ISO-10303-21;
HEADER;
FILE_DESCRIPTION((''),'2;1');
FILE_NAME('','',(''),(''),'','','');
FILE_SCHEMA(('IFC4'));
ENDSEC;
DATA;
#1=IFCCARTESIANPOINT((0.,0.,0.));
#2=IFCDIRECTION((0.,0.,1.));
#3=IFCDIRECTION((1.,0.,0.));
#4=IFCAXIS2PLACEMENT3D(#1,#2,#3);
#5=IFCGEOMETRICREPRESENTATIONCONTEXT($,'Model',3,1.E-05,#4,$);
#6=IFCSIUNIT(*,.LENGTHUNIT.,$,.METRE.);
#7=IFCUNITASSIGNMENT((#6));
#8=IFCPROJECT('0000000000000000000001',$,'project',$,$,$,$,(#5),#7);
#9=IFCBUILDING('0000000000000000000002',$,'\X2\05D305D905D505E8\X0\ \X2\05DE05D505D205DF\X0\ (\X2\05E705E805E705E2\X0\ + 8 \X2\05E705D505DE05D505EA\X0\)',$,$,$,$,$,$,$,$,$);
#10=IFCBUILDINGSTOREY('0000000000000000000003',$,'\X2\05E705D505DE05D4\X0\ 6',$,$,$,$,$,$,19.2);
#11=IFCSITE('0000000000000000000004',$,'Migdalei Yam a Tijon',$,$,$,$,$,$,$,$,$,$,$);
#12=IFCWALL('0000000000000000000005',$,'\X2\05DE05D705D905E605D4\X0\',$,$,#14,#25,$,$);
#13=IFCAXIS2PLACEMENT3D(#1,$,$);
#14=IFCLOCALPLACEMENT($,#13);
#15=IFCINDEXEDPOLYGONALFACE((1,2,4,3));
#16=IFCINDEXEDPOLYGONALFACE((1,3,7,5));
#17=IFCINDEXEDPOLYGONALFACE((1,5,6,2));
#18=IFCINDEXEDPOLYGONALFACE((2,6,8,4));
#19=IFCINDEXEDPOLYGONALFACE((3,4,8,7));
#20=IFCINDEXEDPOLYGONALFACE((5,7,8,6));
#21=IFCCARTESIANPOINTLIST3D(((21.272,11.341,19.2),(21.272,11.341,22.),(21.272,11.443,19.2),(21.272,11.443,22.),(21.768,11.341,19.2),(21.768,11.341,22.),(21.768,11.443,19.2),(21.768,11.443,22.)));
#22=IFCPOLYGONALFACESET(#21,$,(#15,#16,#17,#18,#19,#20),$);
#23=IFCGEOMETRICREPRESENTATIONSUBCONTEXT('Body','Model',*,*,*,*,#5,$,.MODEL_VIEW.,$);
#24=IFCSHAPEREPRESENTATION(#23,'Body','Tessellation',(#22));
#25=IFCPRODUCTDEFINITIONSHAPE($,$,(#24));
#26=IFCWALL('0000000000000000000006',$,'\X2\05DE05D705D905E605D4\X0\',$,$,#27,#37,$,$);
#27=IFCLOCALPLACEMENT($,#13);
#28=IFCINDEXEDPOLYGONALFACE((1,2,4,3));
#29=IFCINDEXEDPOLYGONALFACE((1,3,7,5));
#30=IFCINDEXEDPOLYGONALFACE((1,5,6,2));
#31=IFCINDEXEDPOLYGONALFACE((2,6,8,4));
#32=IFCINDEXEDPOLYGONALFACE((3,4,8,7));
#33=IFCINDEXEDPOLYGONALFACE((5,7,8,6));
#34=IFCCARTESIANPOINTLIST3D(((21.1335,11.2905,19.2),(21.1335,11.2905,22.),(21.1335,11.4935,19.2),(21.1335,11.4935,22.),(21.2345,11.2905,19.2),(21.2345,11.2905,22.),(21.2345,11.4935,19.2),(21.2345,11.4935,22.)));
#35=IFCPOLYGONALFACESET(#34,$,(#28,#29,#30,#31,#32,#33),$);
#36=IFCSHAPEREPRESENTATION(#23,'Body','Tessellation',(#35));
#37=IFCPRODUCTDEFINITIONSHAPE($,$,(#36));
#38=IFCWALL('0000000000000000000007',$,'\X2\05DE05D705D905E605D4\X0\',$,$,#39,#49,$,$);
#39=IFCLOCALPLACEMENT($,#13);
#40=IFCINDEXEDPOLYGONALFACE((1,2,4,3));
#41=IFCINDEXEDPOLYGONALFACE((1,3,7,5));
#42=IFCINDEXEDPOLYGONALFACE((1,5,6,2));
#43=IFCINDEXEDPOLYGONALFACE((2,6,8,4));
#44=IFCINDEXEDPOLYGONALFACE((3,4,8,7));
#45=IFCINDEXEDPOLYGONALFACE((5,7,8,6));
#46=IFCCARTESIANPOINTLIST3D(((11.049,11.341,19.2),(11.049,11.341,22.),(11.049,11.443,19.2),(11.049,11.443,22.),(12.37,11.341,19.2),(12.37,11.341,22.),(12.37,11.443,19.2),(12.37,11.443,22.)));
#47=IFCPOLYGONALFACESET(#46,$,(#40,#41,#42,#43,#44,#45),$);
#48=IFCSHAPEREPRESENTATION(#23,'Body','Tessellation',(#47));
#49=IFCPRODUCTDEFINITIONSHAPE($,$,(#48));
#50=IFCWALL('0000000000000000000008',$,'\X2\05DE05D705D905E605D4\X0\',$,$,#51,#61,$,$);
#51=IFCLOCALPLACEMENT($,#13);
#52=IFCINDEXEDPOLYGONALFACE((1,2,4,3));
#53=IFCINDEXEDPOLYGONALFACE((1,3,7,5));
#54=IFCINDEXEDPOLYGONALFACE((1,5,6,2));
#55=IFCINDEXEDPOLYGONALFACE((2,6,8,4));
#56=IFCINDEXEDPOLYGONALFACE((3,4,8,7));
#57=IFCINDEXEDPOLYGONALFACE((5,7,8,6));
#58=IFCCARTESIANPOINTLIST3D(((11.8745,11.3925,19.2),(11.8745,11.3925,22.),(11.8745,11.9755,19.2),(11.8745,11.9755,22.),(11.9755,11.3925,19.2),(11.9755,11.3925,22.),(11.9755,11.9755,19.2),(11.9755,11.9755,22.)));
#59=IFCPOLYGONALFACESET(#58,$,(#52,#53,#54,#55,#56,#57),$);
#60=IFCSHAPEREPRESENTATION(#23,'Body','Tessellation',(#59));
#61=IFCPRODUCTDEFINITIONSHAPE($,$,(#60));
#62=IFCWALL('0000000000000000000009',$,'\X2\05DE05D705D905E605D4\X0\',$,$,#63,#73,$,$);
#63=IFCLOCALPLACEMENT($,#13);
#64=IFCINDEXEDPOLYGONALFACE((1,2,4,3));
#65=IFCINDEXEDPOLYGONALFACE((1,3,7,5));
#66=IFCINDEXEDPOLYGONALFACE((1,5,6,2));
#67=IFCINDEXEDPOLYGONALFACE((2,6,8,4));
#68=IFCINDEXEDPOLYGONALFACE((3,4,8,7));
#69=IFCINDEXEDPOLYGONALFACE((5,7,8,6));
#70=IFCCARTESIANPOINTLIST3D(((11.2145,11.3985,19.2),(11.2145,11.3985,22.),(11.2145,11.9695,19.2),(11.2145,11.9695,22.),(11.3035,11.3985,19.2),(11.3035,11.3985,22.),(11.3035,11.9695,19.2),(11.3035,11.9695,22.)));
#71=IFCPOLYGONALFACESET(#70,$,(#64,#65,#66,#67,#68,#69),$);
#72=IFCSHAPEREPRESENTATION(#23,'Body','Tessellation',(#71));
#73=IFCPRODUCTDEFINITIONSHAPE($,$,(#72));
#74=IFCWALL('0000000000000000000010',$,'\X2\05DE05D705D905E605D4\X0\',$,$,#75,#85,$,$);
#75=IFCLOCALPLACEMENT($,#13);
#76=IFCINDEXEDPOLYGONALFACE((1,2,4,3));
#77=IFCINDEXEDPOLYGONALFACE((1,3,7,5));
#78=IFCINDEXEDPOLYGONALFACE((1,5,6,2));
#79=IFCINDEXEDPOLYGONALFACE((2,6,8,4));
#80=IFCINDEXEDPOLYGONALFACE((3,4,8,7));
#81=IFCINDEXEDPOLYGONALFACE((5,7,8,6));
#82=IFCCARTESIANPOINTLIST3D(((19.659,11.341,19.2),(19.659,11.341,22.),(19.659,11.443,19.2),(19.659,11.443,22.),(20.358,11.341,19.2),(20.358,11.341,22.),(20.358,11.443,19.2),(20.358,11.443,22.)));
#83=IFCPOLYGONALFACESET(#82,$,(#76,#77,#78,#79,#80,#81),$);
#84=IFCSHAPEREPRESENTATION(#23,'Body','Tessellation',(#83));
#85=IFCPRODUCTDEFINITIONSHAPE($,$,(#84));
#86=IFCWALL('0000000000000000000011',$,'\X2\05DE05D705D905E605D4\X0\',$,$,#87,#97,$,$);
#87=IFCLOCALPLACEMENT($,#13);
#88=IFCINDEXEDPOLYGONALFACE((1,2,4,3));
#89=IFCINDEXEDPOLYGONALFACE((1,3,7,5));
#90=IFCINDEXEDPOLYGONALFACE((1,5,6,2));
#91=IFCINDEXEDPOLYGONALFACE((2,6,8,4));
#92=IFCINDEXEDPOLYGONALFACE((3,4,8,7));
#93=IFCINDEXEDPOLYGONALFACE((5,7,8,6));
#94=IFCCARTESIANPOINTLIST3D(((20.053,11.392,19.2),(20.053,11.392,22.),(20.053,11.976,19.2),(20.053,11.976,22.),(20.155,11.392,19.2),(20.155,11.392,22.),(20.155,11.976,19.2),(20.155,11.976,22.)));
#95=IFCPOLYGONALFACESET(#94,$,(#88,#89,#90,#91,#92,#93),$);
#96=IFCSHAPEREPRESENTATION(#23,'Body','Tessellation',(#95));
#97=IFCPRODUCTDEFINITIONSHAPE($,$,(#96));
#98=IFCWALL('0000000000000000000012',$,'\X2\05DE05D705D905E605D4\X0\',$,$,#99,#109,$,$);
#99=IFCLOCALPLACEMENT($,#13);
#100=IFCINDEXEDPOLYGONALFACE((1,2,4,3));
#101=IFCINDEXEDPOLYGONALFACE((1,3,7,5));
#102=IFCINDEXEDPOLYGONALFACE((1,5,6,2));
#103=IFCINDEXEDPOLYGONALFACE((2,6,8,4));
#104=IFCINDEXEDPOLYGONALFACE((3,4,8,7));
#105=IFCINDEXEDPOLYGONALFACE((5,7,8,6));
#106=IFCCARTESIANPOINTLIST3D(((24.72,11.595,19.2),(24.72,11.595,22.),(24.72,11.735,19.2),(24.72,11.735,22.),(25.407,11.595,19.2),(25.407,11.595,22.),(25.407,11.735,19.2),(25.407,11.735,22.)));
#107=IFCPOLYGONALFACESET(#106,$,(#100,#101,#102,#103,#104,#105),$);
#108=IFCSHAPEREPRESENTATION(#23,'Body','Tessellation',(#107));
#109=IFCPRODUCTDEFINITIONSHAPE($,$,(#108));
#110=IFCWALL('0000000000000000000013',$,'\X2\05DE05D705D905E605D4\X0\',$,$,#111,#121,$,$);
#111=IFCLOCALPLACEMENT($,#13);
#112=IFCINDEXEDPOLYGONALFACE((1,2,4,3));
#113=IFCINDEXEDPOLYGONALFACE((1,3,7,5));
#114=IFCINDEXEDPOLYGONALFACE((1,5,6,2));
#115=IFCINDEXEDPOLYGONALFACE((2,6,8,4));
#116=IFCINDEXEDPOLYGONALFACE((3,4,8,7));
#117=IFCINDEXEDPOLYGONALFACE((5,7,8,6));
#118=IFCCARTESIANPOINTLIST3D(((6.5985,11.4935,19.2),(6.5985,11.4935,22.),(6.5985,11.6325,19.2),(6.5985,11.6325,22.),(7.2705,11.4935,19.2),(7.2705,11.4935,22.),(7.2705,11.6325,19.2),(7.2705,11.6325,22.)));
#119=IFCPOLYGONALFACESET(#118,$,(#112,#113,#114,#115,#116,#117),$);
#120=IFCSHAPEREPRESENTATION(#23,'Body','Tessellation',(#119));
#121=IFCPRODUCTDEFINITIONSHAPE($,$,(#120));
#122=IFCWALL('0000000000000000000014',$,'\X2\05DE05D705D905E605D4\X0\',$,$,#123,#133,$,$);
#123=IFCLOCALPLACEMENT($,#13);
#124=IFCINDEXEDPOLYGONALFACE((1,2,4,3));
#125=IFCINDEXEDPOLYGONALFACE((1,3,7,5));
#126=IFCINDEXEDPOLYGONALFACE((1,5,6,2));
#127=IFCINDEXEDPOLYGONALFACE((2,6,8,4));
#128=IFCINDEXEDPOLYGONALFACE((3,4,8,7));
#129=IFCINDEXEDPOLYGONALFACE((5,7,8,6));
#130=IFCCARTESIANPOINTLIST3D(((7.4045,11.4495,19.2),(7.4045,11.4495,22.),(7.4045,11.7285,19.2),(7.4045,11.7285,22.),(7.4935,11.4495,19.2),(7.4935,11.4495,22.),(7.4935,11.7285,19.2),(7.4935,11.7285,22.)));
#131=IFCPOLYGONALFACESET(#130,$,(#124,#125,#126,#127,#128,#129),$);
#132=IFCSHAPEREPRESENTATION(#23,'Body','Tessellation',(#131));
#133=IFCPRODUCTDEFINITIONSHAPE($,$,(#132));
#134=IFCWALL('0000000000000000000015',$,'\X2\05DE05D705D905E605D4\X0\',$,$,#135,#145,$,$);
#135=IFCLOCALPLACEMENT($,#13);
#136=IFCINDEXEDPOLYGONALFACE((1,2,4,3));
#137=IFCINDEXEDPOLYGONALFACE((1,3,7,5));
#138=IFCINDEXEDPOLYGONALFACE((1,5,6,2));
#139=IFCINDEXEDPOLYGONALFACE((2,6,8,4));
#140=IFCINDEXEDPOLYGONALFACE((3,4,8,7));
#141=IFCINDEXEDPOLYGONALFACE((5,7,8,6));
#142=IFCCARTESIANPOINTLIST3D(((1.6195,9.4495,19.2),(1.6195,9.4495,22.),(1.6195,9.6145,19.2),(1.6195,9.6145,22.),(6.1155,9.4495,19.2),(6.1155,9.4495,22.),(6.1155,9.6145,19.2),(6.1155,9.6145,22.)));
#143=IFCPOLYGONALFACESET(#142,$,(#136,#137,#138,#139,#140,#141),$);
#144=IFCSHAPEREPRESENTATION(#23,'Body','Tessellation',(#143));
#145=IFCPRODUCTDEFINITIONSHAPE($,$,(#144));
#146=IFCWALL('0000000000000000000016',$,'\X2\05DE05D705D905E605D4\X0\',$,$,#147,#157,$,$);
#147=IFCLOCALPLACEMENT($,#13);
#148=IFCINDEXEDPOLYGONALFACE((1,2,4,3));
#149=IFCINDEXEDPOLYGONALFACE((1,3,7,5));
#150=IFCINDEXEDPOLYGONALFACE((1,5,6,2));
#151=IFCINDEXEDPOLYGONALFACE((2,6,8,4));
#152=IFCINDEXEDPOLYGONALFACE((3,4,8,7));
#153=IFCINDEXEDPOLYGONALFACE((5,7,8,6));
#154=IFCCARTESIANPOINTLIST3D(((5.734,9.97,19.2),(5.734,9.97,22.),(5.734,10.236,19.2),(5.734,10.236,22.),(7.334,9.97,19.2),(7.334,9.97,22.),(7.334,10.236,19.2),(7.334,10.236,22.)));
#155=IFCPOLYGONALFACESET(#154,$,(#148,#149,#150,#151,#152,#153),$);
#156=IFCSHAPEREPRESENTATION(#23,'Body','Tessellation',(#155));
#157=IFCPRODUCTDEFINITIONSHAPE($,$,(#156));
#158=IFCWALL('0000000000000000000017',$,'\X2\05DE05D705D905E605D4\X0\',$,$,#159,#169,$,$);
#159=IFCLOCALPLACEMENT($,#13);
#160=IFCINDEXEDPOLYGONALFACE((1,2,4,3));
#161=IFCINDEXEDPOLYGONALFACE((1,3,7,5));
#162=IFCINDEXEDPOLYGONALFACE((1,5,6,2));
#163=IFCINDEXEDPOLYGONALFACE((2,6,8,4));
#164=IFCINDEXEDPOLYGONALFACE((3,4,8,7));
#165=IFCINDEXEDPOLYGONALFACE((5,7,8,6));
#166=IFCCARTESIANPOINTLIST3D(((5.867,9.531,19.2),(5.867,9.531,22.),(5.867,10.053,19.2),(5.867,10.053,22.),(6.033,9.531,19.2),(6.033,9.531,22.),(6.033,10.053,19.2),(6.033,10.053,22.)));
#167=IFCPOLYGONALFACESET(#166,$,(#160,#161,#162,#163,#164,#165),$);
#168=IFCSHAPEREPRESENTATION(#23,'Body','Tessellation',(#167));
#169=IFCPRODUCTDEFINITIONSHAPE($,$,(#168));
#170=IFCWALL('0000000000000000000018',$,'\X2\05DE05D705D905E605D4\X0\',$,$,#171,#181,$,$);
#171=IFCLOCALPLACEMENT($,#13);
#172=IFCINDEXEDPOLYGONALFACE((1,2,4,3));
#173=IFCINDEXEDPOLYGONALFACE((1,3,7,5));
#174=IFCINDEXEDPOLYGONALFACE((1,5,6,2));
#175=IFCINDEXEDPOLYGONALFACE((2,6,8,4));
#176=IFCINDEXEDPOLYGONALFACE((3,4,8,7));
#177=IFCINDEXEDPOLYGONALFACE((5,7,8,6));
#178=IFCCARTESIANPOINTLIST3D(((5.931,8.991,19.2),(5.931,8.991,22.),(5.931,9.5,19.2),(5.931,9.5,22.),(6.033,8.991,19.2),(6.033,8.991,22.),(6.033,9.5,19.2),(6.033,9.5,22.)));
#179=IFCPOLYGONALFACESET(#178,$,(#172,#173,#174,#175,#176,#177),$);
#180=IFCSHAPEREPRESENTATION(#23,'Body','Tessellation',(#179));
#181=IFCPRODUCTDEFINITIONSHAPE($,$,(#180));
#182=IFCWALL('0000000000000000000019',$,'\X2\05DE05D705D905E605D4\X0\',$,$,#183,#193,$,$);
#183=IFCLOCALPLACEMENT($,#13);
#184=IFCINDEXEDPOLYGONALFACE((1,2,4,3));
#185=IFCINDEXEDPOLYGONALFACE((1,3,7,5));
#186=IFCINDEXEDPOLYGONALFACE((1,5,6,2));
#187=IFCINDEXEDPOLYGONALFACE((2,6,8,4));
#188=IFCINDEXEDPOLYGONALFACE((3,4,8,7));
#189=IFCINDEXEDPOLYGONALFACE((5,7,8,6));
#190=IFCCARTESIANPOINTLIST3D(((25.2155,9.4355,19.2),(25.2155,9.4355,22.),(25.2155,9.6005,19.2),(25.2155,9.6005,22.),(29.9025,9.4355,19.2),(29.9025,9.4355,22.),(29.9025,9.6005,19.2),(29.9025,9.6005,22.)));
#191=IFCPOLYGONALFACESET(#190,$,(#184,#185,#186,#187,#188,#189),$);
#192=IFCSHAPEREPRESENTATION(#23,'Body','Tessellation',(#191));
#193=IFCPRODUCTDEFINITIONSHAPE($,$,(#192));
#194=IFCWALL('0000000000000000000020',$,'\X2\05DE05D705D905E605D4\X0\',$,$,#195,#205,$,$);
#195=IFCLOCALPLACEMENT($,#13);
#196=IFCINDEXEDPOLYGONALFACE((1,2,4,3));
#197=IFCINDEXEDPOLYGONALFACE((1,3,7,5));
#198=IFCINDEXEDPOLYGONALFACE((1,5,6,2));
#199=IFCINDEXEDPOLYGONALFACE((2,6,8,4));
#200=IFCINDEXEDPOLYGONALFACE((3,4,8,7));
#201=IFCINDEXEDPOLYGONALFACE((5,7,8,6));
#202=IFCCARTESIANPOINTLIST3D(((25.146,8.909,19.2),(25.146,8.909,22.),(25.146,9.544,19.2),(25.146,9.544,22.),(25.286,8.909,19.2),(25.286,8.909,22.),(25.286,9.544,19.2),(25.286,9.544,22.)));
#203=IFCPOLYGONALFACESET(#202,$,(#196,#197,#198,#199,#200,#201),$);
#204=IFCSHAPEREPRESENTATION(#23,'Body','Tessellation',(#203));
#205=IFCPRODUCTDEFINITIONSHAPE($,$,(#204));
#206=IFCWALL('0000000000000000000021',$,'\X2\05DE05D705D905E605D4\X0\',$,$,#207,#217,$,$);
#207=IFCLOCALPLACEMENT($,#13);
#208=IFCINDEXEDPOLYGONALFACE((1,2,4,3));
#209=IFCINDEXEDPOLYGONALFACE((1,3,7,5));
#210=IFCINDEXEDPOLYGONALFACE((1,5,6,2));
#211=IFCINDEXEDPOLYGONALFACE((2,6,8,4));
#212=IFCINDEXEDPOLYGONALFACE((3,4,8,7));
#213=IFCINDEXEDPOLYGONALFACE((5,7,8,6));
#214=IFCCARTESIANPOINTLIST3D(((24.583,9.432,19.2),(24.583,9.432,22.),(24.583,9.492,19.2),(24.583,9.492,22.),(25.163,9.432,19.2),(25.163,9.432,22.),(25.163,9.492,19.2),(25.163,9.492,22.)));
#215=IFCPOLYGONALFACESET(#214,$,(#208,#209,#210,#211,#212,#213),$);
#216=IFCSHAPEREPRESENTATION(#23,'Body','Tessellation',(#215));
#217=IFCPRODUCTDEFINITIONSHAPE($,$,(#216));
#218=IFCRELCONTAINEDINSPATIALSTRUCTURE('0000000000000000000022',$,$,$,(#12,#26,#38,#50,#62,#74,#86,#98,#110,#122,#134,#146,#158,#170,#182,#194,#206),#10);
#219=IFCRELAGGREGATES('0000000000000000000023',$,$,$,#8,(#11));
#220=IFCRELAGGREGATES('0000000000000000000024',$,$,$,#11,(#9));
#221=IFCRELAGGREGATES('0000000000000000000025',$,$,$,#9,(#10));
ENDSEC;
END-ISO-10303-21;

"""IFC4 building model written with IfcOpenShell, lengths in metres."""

from ifc_helpers import new_model, si_unit, frame, origin_with_axes, context, subcontext, project, spatial, line, indexed_curve, outline, extrude, element, save


model = new_model("IFC4")

# Units and contexts
model_context = context("Model", 3, precision=1e-05, world=origin_with_axes())
body_context = subcontext(model_context, "Body", "Model", "MODEL_VIEW")
ifc_project = project(units=[si_unit("LENGTHUNIT", "METRE")], contexts=[model_context])

# Site, building, storey
site = spatial("IfcSite", under=ifc_project, Name="Migdalei Yam a Tijon")
building = spatial("IfcBuilding", under=site, Name="דיור מוגן (קרקע + 8 קומות)")
storey = spatial("IfcBuildingStorey", under=building, Name="קומה 6", Elevation=19.2)

# Walls
element("IfcWall", 1, inside=storey, Name="מחיצה", context=body_context, shape_type="SweptSolid", body=[
    extrude(outline(indexed_curve([(0.0, 0.0), (0.496, 0.0), (0.496, 0.102), (0.0, 0.102)], segments=[line(1, 2, 3, 4, 1)])), frame((21.272, 11.341, 19.2), z_axis=(0.0, 0.0, 1.0), x_axis=(1.0, 0.0, 0.0)), (0.0, 0.0, 1.0), 2.8),
])
element("IfcWall", 2, inside=storey, Name="מחיצה", context=body_context, shape_type="SweptSolid", body=[
    extrude(outline(indexed_curve([(0.0, 0.0), (0.101, 0.0), (0.101, 0.203), (0.0, 0.203)], segments=[line(1, 2, 3, 4, 1)])), frame((21.1335, 11.2905, 19.2), z_axis=(0.0, 0.0, 1.0), x_axis=(1.0, 0.0, 0.0)), (0.0, 0.0, 1.0), 2.8),
])
element("IfcWall", 3, inside=storey, Name="מחיצה", context=body_context, shape_type="SweptSolid", body=[
    extrude(outline(indexed_curve([(0.0, 0.0), (1.321, 0.0), (1.321, 0.102), (0.0, 0.102)], segments=[line(1, 2, 3, 4, 1)])), frame((11.049, 11.341, 19.2), z_axis=(0.0, 0.0, 1.0), x_axis=(1.0, 0.0, 0.0)), (0.0, 0.0, 1.0), 2.8),
])
element("IfcWall", 4, inside=storey, Name="מחיצה", context=body_context, shape_type="SweptSolid", body=[
    extrude(outline(indexed_curve([(0.0, 0.0), (0.101, 0.0), (0.101, 0.583), (0.0, 0.583)], segments=[line(1, 2, 3, 4, 1)])), frame((11.8745, 11.3925, 19.2), z_axis=(0.0, 0.0, 1.0), x_axis=(1.0, 0.0, 0.0)), (0.0, 0.0, 1.0), 2.8),
])
element("IfcWall", 5, inside=storey, Name="מחיצה", context=body_context, shape_type="SweptSolid", body=[
    extrude(outline(indexed_curve([(0.0, 0.0), (0.089, 0.0), (0.089, 0.571), (0.0, 0.571)], segments=[line(1, 2, 3, 4, 1)])), frame((11.2145, 11.3985, 19.2), z_axis=(0.0, 0.0, 1.0), x_axis=(1.0, 0.0, 0.0)), (0.0, 0.0, 1.0), 2.8),
])
element("IfcWall", 6, inside=storey, Name="מחיצה", context=body_context, shape_type="SweptSolid", body=[
    extrude(outline(indexed_curve([(0.0, 0.0), (0.699, 0.0), (0.699, 0.102), (0.0, 0.102)], segments=[line(1, 2, 3, 4, 1)])), frame((19.659, 11.341, 19.2), z_axis=(0.0, 0.0, 1.0), x_axis=(1.0, 0.0, 0.0)), (0.0, 0.0, 1.0), 2.8),
])
element("IfcWall", 7, inside=storey, Name="מחיצה", context=body_context, shape_type="SweptSolid", body=[
    extrude(outline(indexed_curve([(0.0, 0.0), (0.102, 0.0), (0.102, 0.584), (0.0, 0.584)], segments=[line(1, 2, 3, 4, 1)])), frame((20.053, 11.392, 19.2), z_axis=(0.0, 0.0, 1.0), x_axis=(1.0, 0.0, 0.0)), (0.0, 0.0, 1.0), 2.8),
])
element("IfcWall", 8, inside=storey, Name="מחיצה", context=body_context, shape_type="SweptSolid", body=[
    extrude(outline(indexed_curve([(0.0, 0.0), (0.687, 0.0), (0.687, 0.14), (0.0, 0.14)], segments=[line(1, 2, 3, 4, 1)])), frame((24.72, 11.595, 19.2), z_axis=(0.0, 0.0, 1.0), x_axis=(1.0, 0.0, 0.0)), (0.0, 0.0, 1.0), 2.8),
])
element("IfcWall", 9, inside=storey, Name="מחיצה", context=body_context, shape_type="SweptSolid", body=[
    extrude(outline(indexed_curve([(0.0, 0.0), (0.672, 0.0), (0.672, 0.139), (0.0, 0.139)], segments=[line(1, 2, 3, 4, 1)])), frame((6.5985, 11.4935, 19.2), z_axis=(0.0, 0.0, 1.0), x_axis=(1.0, 0.0, 0.0)), (0.0, 0.0, 1.0), 2.8),
])
element("IfcWall", 10, inside=storey, Name="מחיצה", context=body_context, shape_type="SweptSolid", body=[
    extrude(outline(indexed_curve([(0.0, 0.0), (0.089, 0.0), (0.089, 0.279), (0.0, 0.279)], segments=[line(1, 2, 3, 4, 1)])), frame((7.4045, 11.4495, 19.2), z_axis=(0.0, 0.0, 1.0), x_axis=(1.0, 0.0, 0.0)), (0.0, 0.0, 1.0), 2.8),
])
element("IfcWall", 11, inside=storey, Name="מחיצה", context=body_context, shape_type="SweptSolid", body=[
    extrude(outline(indexed_curve([(0.0, 0.0), (4.496, 0.0), (4.496, 0.165), (0.0, 0.165)], segments=[line(1, 2, 3, 4, 1)])), frame((1.6195, 9.4495, 19.2), z_axis=(0.0, 0.0, 1.0), x_axis=(1.0, 0.0, 0.0)), (0.0, 0.0, 1.0), 2.8),
])
element("IfcWall", 12, inside=storey, Name="מחיצה", context=body_context, shape_type="SweptSolid", body=[
    extrude(outline(indexed_curve([(0.0, 0.0), (1.6, 0.0), (1.6, 0.266), (0.0, 0.266)], segments=[line(1, 2, 3, 4, 1)])), frame((5.734, 9.97, 19.2), z_axis=(0.0, 0.0, 1.0), x_axis=(1.0, 0.0, 0.0)), (0.0, 0.0, 1.0), 2.8),
])
element("IfcWall", 13, inside=storey, Name="מחיצה", context=body_context, shape_type="SweptSolid", body=[
    extrude(outline(indexed_curve([(0.0, 0.0), (0.166, 0.0), (0.166, 0.522), (0.0, 0.522)], segments=[line(1, 2, 3, 4, 1)])), frame((5.867, 9.531, 19.2), z_axis=(0.0, 0.0, 1.0), x_axis=(1.0, 0.0, 0.0)), (0.0, 0.0, 1.0), 2.8),
])
element("IfcWall", 14, inside=storey, Name="מחיצה", context=body_context, shape_type="SweptSolid", body=[
    extrude(outline(indexed_curve([(0.0, 0.0), (0.102, 0.0), (0.102, 0.509), (0.0, 0.509)], segments=[line(1, 2, 3, 4, 1)])), frame((5.931, 8.991, 19.2), z_axis=(0.0, 0.0, 1.0), x_axis=(1.0, 0.0, 0.0)), (0.0, 0.0, 1.0), 2.8),
])
element("IfcWall", 15, inside=storey, Name="מחיצה", context=body_context, shape_type="SweptSolid", body=[
    extrude(outline(indexed_curve([(0.0, 0.0), (4.687, 0.0), (4.687, 0.165), (0.0, 0.165)], segments=[line(1, 2, 3, 4, 1)])), frame((25.2155, 9.4355, 19.2), z_axis=(0.0, 0.0, 1.0), x_axis=(1.0, 0.0, 0.0)), (0.0, 0.0, 1.0), 2.8),
])
element("IfcWall", 16, inside=storey, Name="מחיצה", context=body_context, shape_type="SweptSolid", body=[
    extrude(outline(indexed_curve([(0.0, 0.0), (0.14, 0.0), (0.14, 0.635), (0.0, 0.635)], segments=[line(1, 2, 3, 4, 1)])), frame((25.146, 8.909, 19.2), z_axis=(0.0, 0.0, 1.0), x_axis=(1.0, 0.0, 0.0)), (0.0, 0.0, 1.0), 2.8),
])
element("IfcWall", 17, inside=storey, Name="מחיצה", context=body_context, shape_type="SweptSolid", body=[
    extrude(outline(indexed_curve([(0.0, 0.0), (0.58, 0.0), (0.58, 0.06), (0.0, 0.06)], segments=[line(1, 2, 3, 4, 1)])), frame((24.583, 9.432, 19.2), z_axis=(0.0, 0.0, 1.0), x_axis=(1.0, 0.0, 0.0)), (0.0, 0.0, 1.0), 2.8),
])

save(model, "model.ifc")
